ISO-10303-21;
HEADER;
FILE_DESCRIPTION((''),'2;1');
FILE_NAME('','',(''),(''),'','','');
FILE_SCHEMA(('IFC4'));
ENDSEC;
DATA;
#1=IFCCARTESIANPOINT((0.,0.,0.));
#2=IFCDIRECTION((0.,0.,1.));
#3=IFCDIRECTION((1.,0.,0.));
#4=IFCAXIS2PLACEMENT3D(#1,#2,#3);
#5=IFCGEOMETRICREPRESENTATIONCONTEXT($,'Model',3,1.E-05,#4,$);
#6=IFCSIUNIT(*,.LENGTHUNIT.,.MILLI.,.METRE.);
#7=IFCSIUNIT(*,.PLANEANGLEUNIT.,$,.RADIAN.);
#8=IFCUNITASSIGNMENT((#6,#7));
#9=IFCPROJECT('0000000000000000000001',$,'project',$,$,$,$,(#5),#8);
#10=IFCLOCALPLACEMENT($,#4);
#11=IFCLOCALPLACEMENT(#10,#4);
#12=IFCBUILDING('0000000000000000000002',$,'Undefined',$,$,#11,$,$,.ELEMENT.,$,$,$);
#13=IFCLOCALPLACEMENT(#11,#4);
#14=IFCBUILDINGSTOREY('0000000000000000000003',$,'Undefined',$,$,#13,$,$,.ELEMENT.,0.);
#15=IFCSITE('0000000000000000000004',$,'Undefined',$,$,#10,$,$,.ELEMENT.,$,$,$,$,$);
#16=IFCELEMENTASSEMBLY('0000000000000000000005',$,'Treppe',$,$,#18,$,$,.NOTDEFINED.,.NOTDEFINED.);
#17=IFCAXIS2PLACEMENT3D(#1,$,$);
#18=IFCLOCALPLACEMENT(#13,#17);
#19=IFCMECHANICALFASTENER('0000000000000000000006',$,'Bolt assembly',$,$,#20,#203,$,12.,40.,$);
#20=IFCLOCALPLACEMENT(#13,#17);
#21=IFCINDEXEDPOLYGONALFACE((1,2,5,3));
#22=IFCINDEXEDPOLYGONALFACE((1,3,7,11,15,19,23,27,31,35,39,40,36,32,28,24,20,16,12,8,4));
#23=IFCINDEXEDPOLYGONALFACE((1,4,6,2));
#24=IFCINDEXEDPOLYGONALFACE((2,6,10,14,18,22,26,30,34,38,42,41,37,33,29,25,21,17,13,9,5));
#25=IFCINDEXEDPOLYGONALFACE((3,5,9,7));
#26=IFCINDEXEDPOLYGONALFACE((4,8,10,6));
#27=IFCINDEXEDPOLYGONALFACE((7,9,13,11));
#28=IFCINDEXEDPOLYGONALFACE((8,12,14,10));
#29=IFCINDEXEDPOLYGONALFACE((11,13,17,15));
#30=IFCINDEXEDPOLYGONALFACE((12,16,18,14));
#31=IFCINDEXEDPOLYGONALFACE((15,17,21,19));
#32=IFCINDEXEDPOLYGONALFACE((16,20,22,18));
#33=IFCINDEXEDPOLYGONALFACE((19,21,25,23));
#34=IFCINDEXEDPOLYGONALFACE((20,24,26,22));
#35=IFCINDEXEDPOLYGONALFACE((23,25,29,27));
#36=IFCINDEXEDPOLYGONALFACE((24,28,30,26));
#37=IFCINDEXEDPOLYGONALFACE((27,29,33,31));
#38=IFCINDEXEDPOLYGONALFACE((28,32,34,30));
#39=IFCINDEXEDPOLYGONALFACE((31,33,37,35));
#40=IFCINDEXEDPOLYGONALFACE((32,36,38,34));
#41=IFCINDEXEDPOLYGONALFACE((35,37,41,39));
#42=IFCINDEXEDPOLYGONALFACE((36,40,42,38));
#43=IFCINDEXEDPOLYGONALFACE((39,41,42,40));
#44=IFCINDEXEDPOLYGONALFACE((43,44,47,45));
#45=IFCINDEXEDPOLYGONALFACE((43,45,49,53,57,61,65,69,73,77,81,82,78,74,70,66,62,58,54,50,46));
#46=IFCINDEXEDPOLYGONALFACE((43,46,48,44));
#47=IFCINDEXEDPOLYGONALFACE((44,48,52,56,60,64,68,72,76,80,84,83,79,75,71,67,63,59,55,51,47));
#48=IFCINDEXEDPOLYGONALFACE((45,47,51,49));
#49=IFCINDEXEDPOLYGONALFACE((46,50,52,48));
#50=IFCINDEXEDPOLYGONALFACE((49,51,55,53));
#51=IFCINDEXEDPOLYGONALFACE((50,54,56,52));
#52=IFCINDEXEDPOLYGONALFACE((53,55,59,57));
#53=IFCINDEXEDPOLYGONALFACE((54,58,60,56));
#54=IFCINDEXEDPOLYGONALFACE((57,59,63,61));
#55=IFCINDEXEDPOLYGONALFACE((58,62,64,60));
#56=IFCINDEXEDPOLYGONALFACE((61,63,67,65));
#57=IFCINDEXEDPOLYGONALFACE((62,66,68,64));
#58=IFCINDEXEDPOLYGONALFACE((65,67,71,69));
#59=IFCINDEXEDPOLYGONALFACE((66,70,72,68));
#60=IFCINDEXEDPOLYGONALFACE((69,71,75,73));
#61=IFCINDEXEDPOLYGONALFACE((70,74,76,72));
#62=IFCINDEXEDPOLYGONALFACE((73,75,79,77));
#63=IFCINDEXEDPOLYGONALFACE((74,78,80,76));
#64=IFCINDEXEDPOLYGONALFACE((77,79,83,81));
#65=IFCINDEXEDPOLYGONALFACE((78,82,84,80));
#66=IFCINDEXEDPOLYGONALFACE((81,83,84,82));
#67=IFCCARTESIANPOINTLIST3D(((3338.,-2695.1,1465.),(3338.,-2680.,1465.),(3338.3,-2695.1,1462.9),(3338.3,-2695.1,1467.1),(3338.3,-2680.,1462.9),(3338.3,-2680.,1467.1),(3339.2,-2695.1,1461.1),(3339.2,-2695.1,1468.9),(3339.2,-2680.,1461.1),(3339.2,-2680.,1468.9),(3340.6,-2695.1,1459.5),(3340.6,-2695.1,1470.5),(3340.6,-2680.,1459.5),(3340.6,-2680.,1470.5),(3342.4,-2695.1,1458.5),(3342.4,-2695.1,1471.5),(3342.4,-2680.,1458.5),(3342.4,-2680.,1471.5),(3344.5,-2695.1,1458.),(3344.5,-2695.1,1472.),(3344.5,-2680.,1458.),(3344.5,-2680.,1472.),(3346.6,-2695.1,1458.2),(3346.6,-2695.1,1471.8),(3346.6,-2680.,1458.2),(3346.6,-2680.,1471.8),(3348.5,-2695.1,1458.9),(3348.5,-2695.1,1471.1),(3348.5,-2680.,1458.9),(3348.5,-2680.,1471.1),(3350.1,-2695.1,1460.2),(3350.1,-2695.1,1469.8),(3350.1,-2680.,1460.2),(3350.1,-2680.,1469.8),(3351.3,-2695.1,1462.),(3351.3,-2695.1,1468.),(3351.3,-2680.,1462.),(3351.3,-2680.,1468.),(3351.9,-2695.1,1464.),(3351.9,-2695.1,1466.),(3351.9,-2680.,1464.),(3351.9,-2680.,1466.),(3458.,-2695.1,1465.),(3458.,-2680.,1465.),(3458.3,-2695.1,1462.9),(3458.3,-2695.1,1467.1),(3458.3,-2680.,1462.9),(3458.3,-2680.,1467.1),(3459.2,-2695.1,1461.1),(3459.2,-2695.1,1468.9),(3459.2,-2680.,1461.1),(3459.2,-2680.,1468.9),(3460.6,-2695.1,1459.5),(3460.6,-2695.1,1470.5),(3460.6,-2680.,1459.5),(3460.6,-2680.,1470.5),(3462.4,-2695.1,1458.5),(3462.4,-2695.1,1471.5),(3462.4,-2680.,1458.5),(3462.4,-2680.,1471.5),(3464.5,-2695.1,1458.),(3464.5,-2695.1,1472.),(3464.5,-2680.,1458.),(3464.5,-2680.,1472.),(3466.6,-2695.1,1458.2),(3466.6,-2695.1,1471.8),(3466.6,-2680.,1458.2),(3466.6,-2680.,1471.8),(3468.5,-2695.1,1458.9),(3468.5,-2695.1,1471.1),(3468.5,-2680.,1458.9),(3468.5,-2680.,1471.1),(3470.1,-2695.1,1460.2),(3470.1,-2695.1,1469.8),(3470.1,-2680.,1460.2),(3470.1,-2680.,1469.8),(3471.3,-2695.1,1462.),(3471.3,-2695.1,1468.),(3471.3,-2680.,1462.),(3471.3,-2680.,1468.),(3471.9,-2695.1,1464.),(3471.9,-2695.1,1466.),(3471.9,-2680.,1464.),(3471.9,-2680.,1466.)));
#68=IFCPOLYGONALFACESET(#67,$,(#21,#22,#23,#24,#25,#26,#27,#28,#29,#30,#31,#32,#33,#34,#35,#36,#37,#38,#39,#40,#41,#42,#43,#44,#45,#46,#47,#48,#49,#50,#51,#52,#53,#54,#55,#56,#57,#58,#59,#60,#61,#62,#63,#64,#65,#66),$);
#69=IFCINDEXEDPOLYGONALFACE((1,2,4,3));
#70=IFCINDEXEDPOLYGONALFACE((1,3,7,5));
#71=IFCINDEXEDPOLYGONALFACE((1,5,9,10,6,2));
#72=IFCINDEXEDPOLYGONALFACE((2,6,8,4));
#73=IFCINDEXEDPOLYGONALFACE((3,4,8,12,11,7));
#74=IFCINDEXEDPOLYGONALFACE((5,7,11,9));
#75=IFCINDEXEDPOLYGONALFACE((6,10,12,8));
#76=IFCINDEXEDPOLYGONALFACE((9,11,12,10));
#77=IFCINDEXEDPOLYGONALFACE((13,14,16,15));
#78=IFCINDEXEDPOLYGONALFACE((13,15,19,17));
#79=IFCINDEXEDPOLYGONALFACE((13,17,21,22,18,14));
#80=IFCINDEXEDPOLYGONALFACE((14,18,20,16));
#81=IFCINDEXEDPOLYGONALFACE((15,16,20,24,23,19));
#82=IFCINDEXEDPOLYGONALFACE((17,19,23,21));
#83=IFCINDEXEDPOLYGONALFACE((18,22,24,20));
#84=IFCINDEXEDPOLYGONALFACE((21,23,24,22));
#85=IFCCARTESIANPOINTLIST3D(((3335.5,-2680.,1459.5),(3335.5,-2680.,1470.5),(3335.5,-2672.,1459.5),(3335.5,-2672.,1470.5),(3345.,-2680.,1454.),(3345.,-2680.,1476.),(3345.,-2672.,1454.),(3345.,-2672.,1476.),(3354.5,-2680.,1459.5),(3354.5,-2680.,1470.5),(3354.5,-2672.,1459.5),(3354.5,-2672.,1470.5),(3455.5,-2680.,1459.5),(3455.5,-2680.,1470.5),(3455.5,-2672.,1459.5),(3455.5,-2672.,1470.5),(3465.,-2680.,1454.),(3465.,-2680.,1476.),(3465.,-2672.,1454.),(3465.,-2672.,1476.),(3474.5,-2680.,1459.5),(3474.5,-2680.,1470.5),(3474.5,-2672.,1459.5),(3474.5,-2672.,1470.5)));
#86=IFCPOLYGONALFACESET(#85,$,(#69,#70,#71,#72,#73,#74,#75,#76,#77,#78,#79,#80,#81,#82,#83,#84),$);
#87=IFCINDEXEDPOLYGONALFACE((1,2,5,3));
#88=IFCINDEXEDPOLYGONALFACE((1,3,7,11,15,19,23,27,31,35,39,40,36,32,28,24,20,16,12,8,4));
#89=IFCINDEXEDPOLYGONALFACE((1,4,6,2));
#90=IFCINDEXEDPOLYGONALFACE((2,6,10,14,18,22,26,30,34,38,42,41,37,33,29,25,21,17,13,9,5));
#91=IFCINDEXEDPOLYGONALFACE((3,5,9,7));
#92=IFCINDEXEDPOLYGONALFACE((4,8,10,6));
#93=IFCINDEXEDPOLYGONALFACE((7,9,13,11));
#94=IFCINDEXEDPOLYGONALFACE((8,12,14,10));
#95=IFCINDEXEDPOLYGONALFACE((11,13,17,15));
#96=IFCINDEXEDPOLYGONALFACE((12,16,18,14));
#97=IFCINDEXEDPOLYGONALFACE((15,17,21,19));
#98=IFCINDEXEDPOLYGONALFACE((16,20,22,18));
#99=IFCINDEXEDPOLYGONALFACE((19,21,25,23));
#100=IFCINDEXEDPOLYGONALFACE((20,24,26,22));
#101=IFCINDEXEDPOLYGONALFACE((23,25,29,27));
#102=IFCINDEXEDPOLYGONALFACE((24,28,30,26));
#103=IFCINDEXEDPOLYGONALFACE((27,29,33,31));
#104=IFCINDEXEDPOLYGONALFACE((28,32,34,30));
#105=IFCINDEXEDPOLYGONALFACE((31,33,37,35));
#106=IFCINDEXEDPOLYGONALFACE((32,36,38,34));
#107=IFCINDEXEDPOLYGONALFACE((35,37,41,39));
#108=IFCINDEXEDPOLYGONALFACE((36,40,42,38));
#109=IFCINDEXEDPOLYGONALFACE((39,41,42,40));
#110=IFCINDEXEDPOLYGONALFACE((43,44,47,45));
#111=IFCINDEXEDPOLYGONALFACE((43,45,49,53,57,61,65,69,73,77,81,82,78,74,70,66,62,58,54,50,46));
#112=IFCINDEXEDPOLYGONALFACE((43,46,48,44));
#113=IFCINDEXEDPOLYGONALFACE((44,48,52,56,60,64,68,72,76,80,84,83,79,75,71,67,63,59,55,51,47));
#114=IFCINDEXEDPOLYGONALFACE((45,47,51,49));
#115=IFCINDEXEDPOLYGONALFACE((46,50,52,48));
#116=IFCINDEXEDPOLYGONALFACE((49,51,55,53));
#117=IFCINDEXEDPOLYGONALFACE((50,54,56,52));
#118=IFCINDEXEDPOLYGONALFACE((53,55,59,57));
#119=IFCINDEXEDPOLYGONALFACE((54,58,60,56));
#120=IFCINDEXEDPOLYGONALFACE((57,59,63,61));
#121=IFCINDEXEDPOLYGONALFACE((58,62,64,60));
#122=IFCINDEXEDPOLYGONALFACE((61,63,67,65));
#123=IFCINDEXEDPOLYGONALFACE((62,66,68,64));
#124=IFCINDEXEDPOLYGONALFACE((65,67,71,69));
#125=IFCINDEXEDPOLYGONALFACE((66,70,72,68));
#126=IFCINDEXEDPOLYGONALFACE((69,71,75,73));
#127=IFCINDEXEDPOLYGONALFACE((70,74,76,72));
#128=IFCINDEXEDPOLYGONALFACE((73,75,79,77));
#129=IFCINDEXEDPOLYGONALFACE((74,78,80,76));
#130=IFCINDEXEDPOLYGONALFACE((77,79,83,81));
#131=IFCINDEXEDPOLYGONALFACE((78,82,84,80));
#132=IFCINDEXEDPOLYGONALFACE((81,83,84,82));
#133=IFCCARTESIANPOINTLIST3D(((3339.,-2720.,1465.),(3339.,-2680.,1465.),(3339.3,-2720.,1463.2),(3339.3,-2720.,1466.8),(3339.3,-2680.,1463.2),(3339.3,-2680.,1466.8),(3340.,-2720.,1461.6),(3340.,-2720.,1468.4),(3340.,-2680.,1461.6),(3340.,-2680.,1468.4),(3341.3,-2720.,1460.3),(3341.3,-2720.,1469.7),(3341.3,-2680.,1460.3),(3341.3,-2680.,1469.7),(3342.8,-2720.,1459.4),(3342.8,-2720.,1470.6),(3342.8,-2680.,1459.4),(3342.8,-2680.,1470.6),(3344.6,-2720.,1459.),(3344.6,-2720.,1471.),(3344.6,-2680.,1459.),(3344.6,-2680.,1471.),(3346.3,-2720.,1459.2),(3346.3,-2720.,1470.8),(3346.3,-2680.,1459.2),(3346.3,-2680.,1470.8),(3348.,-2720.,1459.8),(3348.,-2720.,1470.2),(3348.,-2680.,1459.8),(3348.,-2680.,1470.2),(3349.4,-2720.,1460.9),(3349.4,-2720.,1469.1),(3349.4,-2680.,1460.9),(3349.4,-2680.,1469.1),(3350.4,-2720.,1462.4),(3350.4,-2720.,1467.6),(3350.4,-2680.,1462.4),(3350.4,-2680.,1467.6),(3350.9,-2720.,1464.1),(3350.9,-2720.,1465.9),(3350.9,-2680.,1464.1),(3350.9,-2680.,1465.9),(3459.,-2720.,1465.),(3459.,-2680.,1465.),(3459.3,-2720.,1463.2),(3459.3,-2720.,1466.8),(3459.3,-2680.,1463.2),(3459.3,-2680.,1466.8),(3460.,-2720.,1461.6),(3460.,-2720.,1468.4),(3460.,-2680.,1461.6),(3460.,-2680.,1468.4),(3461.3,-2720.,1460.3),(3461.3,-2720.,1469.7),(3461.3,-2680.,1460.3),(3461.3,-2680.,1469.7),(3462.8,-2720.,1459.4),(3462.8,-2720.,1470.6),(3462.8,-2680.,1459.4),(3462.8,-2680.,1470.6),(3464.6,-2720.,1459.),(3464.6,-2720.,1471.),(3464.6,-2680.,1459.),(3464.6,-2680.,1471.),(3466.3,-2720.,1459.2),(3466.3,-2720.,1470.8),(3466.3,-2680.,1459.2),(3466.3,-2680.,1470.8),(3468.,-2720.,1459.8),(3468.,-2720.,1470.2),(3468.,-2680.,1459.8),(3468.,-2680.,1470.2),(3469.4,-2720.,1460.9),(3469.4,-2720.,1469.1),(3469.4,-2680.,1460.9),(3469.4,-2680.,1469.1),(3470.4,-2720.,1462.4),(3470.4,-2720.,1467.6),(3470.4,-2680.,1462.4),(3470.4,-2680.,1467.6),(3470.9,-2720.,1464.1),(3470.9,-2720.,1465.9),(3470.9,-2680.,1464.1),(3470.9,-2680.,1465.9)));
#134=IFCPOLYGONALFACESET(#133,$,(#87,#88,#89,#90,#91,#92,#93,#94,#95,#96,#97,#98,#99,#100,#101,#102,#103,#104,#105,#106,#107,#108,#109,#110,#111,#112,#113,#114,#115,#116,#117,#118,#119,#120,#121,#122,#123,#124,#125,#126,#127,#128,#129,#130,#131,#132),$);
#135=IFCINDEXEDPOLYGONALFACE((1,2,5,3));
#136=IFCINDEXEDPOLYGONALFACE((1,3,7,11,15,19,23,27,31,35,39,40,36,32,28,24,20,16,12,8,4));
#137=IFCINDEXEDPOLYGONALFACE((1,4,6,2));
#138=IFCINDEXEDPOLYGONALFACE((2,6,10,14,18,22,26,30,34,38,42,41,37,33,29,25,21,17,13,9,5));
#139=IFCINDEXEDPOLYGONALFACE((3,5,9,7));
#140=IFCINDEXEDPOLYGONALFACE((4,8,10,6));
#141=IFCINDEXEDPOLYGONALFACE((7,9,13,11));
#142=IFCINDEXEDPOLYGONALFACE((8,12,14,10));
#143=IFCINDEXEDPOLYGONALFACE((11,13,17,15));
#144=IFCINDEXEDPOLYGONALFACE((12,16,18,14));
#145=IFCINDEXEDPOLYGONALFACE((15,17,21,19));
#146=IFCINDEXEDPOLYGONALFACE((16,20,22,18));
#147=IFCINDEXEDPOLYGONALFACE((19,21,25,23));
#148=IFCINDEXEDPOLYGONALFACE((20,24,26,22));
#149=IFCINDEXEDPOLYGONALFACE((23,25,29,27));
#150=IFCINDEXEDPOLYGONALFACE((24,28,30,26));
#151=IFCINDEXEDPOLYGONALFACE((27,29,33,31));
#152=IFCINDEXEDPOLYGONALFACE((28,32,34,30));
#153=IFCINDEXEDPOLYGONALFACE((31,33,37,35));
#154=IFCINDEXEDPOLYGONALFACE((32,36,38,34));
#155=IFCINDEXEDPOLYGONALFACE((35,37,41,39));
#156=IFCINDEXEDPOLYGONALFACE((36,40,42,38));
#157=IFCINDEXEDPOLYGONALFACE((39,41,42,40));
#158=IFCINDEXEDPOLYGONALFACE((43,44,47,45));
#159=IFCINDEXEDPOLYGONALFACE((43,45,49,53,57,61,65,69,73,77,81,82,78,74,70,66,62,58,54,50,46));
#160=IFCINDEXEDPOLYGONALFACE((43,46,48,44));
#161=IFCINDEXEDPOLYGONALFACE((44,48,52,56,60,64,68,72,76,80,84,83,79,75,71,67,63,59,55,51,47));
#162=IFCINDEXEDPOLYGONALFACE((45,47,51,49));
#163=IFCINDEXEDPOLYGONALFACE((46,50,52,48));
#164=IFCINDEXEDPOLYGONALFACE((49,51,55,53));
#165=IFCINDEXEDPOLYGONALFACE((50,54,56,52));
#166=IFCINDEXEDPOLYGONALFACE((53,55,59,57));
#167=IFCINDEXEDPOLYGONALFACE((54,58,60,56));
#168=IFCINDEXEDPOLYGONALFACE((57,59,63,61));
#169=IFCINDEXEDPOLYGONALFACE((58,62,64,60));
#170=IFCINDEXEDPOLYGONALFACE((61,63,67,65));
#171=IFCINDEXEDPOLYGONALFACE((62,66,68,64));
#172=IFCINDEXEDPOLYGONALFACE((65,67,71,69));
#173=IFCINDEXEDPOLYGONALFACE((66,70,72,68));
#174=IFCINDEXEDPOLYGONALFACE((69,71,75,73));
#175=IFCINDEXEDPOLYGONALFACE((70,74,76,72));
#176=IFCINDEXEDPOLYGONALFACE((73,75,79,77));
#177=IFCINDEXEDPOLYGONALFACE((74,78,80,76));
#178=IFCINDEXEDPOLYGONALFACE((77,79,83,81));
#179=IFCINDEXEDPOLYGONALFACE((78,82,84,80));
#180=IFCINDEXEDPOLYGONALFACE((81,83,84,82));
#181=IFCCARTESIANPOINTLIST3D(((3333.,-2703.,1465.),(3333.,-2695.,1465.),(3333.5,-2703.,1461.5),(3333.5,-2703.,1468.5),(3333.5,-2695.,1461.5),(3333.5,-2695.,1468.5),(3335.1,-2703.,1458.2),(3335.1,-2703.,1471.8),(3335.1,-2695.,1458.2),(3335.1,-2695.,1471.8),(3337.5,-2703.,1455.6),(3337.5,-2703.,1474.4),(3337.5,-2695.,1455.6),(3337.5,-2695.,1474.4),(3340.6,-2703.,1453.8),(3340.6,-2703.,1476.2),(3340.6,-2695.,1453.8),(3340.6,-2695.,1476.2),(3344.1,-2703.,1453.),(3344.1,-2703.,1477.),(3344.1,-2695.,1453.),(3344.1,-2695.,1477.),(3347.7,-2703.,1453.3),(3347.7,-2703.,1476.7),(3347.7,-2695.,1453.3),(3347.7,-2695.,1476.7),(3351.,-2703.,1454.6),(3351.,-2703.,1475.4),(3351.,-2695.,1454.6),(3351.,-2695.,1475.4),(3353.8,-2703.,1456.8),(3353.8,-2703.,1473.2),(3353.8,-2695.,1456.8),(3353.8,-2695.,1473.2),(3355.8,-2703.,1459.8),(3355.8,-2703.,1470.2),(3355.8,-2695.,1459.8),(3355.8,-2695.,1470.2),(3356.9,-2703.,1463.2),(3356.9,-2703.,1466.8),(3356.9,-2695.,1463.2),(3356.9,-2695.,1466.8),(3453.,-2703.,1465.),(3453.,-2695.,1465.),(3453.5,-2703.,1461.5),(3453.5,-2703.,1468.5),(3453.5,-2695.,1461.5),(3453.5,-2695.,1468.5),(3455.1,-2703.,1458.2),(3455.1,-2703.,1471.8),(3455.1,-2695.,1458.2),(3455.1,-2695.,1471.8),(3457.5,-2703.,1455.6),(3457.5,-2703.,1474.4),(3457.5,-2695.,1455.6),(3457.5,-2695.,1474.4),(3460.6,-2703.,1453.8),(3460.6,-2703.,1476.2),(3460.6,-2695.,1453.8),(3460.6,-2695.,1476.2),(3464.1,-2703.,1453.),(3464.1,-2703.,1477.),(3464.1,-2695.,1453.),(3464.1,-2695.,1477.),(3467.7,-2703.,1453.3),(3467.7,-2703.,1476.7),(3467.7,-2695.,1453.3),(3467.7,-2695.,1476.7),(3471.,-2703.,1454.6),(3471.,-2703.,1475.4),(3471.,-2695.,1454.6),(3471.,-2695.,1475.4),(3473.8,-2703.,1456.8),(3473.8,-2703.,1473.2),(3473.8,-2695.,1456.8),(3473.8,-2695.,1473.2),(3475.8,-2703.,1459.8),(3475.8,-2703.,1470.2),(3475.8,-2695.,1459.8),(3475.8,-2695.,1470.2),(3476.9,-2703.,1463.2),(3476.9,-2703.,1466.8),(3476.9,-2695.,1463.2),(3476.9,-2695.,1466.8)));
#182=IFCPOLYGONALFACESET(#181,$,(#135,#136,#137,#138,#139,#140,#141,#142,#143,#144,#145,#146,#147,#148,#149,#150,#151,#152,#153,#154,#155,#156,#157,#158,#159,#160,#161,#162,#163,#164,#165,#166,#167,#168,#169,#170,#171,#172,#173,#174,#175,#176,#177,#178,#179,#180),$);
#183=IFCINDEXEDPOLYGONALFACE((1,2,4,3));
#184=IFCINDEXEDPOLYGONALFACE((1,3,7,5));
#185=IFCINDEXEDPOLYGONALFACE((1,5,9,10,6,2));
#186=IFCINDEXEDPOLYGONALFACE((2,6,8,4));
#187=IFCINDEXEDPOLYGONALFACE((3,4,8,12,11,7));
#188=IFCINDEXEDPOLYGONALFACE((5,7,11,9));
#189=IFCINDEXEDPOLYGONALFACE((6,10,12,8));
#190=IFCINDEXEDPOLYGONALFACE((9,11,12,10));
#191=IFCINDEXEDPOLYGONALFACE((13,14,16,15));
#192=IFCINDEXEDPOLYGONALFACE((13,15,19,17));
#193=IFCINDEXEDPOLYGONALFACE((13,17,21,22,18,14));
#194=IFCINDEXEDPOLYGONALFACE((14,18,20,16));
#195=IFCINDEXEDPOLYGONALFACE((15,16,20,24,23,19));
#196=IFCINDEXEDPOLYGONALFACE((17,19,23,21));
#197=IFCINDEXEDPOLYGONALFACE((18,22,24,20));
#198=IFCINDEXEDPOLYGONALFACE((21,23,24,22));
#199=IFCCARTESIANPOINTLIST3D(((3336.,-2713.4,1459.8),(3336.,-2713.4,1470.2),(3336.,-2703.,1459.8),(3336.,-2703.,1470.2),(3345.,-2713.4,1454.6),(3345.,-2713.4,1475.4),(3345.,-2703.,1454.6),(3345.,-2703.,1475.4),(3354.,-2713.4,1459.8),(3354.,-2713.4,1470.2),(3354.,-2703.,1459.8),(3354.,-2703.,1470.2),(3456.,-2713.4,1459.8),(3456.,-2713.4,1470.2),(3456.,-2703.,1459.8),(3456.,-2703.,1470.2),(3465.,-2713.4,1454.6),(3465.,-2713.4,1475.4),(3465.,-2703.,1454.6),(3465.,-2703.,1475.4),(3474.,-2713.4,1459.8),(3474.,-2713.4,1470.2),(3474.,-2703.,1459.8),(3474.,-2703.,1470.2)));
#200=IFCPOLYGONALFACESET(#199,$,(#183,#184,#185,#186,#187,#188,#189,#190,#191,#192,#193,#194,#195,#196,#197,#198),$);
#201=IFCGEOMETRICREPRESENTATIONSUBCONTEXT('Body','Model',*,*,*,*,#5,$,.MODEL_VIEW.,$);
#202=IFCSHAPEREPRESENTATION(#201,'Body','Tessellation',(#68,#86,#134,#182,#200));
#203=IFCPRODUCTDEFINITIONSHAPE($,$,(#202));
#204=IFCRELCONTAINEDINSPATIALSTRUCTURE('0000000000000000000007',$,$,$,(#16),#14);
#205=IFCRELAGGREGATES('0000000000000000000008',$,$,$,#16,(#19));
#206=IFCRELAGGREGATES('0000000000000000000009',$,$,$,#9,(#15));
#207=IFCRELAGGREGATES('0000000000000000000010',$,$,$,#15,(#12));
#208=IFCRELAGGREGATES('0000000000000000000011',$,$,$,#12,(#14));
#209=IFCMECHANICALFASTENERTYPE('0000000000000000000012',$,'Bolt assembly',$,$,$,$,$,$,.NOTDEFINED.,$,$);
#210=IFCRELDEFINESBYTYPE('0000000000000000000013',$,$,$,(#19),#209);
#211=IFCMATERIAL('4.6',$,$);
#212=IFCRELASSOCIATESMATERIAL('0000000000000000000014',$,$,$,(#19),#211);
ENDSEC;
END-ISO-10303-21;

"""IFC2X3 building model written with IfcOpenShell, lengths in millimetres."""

from ifc_helpers import new_model, si_unit, frame, origin_with_axes, origin_2d_with_axis, place, context, subcontext, project, spatial, polyline, circle, outline, extrude, source, transform, mapped, material, type_object, element, aggregate, save


model = new_model("IFC2X3")

# Units and contexts
model_context = context("Model", 3, precision=1e-05, world=origin_with_axes())
body_context = subcontext(model_context, "Body", "Model", "MODEL_VIEW")
ifc_project = project(units=[si_unit("LENGTHUNIT", "METRE", prefix="MILLI"), si_unit("PLANEANGLEUNIT", "RADIAN")], contexts=[model_context])

# Site, building, storey
site_placement = place(None, origin_with_axes())
site = spatial("IfcSite", under=ifc_project, at=site_placement, Name="Undefined", CompositionType="ELEMENT")
building_placement = place(site_placement, origin_with_axes())
building = spatial("IfcBuilding", under=site, at=building_placement, Name="Undefined", CompositionType="ELEMENT")
storey_placement = place(building_placement, origin_with_axes())
storey = spatial("IfcBuildingStorey", under=building, at=storey_placement, Name="Undefined", CompositionType="ELEMENT", Elevation=0.0)

# Element assembly, mechanical fastener
ifc_material_1 = material(Name="4.6")
mechanical_fastener_type = type_object("IfcMechanicalFastenerType", Name="Bolt assembly")
assembly_1_placement = place(storey_placement, origin_with_axes())
assembly_1 = element("IfcElementAssembly", 1, at=assembly_1_placement, inside=storey, Name="Treppe", AssemblyPlace="NOTDEFINED", PredefinedType="NOTDEFINED")
shared_shape_1 = source(origin_with_axes(), body_context, "Body", "SweptSolid", [
    extrude(circle(Radius=7.0, at=origin_2d_with_axis()), frame((0.0, -15.0, 0.0), z_axis=(0.0, 1.0, 0.0), x_axis=(1.0, 0.0, 0.0)), (0.0, 0.0, 1.0), 15.1),
    extrude(outline(polyline([(9.5, -5.5), (9.5, 5.5), (0.0, 11.0), (-9.5, 5.5), (-9.5, -5.5), (0.0, -11.0), (9.5, -5.5)])), frame((0.0, -23.0, 0.0), z_axis=(0.0, 1.0, 0.0), x_axis=(1.0, 0.0, 0.0)), (0.0, 0.0, 1.0), 8.0),
    extrude(circle(Radius=6.0, at=origin_2d_with_axis()), frame((0.0, -15.0, 0.0), z_axis=(0.0, 1.0, 0.0), x_axis=(1.0, 0.0, 0.0)), (0.0, 0.0, 1.0), 40.0),
    extrude(circle(Radius=12.0, at=origin_2d_with_axis()), frame((0.0, 0.0, 0.0), z_axis=(0.0, 1.0, 0.0), x_axis=(1.0, 0.0, 0.0)), (0.0, 0.0, 1.0), 8.0),
    extrude(outline(polyline([(9.0, -5.2), (9.0, 5.2), (0.0, 10.4), (-9.0, 5.2), (-9.0, -5.2), (0.0, -10.4), (9.0, -5.2)])), frame((0.0, 8.0, 0.0), z_axis=(0.0, 1.0, 0.0), x_axis=(1.0, 0.0, 0.0)), (0.0, 0.0, 1.0), 10.4),
])
mechanical_fastener_1_placement = place(assembly_1_placement, frame((3465.0, -2695.0, 1465.0), z_axis=(0.0, 0.0, 1.0), x_axis=(-1.0, 0.0, 0.0)))
mechanical_fastener_1 = element("IfcMechanicalFastener", 2, at=mechanical_fastener_1_placement, type_object=mechanical_fastener_type, material=ifc_material_1, Name="Bolt assembly", NominalDiameter=12.0, NominalLength=40.0, context=body_context, shape_type="MappedRepresentation", body=[
    mapped(shared_shape_1, transform((0.0, 0.0, 0.0))),
    mapped(shared_shape_1, transform((120.0, 0.0, 0.0))),
])
aggregate(assembly_1, [mechanical_fastener_1])

save(model, "model.ifc")
